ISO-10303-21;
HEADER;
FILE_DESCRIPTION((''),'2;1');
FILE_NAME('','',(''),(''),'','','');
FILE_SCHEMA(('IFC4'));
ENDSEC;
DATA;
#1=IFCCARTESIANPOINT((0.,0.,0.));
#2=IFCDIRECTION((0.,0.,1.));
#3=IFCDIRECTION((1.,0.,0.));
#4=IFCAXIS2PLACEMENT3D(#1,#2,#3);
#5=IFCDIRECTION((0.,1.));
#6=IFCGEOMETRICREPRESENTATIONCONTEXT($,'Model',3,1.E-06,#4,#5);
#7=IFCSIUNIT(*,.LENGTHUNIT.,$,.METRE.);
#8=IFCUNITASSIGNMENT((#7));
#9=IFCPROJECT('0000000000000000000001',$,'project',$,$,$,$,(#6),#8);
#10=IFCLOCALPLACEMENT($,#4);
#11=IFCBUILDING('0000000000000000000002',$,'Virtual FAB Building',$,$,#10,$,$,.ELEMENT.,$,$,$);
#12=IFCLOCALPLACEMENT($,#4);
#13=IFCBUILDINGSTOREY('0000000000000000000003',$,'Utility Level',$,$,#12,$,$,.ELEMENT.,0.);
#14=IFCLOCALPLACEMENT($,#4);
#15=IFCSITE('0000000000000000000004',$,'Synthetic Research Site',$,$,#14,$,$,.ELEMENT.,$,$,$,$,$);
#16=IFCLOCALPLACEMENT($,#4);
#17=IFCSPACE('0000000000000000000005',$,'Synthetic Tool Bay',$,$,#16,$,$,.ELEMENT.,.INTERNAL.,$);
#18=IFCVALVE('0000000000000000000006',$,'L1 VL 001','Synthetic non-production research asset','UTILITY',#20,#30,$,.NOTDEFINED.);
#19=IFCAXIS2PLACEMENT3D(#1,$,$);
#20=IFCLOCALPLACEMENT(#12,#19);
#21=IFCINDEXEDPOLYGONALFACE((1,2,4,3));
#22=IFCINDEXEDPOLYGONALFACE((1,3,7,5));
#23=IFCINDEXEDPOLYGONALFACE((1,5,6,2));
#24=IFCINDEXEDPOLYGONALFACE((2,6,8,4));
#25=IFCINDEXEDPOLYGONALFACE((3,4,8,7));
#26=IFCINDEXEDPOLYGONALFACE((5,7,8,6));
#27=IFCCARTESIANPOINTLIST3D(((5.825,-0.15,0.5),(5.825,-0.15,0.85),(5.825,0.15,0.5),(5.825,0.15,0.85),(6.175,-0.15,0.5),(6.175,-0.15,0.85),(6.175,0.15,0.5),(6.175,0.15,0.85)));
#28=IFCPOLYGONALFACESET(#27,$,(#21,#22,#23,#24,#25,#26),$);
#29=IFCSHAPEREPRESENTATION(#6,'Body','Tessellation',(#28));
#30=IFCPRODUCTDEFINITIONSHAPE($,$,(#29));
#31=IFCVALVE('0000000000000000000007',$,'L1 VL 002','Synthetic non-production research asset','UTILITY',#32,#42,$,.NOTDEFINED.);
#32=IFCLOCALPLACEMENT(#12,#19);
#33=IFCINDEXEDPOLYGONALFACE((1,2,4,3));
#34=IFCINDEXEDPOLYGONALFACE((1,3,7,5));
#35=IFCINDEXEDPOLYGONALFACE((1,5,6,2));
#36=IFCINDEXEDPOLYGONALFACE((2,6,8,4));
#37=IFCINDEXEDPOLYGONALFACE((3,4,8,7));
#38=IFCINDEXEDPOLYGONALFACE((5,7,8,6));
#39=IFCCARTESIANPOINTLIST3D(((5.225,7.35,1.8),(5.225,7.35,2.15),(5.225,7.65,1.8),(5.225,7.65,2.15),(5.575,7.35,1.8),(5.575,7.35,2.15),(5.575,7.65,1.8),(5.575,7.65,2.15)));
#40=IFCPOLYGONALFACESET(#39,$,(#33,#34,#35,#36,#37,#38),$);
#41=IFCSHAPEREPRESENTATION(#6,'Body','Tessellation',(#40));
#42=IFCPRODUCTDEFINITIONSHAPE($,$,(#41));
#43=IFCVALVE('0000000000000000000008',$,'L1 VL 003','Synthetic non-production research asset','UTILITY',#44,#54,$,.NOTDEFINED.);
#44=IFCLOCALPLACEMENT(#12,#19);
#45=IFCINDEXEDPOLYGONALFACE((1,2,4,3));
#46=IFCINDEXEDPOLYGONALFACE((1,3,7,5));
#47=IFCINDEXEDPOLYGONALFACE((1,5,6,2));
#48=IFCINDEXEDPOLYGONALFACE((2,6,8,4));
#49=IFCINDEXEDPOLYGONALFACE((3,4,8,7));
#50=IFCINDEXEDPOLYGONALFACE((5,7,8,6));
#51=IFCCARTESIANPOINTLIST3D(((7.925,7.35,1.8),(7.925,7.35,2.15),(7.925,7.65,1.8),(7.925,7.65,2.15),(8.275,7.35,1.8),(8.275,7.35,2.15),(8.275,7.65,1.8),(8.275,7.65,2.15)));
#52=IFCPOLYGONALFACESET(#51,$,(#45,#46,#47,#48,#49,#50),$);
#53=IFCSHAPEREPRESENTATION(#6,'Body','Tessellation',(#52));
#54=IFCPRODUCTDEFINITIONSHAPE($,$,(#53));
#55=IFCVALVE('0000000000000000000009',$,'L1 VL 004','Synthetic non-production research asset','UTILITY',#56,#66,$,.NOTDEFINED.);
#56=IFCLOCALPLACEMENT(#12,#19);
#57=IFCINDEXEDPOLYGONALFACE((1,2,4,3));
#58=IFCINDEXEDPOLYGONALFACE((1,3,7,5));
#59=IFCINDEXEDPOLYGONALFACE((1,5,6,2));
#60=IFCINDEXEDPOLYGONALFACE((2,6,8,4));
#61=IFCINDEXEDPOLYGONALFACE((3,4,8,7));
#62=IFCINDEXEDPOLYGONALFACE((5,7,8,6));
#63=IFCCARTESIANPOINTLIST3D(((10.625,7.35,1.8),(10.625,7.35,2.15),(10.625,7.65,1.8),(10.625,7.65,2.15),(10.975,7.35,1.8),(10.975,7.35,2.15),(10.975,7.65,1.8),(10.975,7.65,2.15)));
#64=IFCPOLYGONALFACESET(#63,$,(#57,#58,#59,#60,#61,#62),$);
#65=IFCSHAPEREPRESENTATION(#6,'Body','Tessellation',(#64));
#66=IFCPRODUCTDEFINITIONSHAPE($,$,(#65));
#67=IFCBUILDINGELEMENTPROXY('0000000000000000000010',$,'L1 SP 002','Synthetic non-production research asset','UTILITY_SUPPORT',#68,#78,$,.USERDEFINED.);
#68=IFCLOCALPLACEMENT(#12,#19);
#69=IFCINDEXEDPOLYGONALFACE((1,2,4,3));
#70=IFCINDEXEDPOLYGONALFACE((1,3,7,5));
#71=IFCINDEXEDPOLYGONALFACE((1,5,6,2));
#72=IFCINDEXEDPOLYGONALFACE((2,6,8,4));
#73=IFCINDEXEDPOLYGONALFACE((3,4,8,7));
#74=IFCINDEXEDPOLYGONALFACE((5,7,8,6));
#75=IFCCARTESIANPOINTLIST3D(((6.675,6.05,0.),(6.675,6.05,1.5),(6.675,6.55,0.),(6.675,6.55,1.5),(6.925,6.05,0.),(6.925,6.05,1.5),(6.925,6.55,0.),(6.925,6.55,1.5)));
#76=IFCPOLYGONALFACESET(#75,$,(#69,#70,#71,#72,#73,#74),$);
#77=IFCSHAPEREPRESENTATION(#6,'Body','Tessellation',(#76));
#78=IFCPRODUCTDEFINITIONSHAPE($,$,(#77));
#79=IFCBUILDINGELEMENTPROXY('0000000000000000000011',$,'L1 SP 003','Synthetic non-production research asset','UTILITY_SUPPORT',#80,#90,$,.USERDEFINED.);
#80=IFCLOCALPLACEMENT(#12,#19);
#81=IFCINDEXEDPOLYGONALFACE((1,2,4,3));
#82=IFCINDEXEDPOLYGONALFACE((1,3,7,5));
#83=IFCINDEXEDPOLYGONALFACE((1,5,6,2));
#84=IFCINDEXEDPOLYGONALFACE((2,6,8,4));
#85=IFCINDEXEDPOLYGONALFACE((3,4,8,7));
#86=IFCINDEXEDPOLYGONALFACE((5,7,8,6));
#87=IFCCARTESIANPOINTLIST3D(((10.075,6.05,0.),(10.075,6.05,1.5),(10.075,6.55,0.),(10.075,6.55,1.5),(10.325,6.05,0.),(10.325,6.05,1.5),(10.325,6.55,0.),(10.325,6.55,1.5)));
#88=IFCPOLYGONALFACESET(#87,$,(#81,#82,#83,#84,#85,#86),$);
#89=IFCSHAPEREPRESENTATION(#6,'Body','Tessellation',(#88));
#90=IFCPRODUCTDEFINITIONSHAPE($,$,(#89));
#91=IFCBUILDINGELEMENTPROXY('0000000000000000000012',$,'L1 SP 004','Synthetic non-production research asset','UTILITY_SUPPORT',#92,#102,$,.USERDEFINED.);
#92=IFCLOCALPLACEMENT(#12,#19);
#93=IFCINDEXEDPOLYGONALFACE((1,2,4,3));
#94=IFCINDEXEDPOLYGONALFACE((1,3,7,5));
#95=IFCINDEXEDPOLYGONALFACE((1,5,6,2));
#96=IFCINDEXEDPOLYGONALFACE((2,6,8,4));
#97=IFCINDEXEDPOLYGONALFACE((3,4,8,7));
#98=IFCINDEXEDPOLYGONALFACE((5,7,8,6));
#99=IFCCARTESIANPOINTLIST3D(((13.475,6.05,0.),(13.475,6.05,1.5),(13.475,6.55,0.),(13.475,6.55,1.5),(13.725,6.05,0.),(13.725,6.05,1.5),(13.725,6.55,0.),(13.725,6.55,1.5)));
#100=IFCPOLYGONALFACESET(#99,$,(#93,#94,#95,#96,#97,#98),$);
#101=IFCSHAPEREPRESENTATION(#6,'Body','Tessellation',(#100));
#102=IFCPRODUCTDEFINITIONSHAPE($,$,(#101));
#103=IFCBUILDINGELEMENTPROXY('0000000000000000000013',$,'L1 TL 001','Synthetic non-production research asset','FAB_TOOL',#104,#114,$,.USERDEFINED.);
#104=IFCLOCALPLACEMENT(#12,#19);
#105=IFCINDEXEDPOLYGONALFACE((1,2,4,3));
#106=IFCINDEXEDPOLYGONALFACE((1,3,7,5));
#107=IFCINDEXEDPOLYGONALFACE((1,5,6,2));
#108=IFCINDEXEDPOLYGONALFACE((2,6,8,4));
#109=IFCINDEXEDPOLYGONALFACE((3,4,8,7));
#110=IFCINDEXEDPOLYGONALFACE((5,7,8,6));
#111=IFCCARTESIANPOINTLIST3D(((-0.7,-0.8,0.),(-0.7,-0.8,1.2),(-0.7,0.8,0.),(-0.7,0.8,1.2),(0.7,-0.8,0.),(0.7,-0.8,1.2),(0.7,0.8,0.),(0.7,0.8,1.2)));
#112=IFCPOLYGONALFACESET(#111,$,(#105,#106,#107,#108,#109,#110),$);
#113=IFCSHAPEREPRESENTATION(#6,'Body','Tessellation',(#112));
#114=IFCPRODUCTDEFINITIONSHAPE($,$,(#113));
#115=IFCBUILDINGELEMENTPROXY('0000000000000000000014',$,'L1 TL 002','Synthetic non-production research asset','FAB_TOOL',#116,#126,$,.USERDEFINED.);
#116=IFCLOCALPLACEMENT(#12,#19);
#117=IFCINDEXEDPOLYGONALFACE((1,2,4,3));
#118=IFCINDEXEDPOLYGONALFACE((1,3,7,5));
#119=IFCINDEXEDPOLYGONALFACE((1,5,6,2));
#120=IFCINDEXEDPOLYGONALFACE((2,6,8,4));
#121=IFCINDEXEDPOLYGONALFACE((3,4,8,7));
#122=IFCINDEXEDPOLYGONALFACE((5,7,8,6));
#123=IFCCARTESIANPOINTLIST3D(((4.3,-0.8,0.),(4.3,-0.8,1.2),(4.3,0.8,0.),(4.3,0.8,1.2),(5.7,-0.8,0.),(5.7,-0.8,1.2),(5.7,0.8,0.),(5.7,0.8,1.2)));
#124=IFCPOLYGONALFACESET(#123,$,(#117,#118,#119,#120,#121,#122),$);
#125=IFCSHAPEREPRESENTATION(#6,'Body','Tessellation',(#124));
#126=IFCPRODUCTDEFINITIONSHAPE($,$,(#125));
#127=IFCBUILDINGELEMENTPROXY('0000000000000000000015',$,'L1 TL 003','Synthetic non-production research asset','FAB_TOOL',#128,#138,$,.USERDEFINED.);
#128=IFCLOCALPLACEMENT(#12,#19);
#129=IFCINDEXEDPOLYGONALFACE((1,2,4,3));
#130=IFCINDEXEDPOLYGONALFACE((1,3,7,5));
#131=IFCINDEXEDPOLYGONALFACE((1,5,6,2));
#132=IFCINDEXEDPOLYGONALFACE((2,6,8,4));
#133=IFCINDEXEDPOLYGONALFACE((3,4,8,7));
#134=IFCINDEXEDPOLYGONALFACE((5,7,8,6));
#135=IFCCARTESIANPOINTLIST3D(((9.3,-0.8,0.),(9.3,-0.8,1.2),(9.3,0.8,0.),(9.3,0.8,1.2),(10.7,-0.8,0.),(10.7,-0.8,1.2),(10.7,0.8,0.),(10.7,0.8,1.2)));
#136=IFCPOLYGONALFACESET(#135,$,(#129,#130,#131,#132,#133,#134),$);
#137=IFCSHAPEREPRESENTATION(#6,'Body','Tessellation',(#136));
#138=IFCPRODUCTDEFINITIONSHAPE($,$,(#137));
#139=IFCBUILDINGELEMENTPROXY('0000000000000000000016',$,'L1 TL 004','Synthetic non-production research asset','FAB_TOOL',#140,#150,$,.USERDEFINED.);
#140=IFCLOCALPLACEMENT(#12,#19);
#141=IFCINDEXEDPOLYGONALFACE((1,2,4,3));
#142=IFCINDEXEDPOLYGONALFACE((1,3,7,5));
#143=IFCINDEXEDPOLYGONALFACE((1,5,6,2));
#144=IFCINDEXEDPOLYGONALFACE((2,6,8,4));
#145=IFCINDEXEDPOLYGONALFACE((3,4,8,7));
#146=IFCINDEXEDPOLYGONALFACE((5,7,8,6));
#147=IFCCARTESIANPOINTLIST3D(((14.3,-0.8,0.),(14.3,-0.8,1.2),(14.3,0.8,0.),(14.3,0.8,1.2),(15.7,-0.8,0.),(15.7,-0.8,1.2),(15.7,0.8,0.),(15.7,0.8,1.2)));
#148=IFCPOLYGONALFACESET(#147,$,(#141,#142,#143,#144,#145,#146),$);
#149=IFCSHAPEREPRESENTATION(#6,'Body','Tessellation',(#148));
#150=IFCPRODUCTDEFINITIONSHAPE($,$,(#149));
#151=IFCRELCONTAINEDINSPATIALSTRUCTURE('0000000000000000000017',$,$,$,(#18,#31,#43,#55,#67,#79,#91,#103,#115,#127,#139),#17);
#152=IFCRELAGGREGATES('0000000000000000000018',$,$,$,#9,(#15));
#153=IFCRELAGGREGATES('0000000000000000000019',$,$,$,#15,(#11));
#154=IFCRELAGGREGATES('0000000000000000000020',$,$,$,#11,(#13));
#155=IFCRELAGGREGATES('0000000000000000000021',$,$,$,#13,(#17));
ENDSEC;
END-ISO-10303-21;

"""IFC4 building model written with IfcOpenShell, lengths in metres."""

from ifc_helpers import new_model, si_unit, direction, frame, origin_with_axes, origin_2d_with_axis, place, context, project, spatial, rectangle, extrude, element, save


model = new_model("IFC4")

# Units and contexts
model_context = context("Model", 3, precision=1e-06, world=origin_with_axes(), true_north=direction((0.0, 1.0)))
ifc_project = project(units=[si_unit("LENGTHUNIT", "METRE")], contexts=[model_context])

# Site, building, storey, space
site_placement = place(None, origin_with_axes())
site = spatial("IfcSite", under=ifc_project, at=site_placement, Name="Synthetic Research Site", CompositionType="ELEMENT")
building_placement = place(None, origin_with_axes())
building = spatial("IfcBuilding", under=site, at=building_placement, Name="Virtual FAB Building", CompositionType="ELEMENT")
storey_placement = place(None, origin_with_axes())
storey = spatial("IfcBuildingStorey", under=building, at=storey_placement, Name="Utility Level", CompositionType="ELEMENT", Elevation=0.0)
space_placement = place(None, origin_with_axes())
space = spatial("IfcSpace", under=storey, at=space_placement, Name="Synthetic Tool Bay", CompositionType="ELEMENT", PredefinedType="INTERNAL")

# Valves
for number, where, z_axis, x_axis, name in (
    (1, (6.0, 0.0, 0.5), (0.0, 0.0, 1.0), (1.0, 0.0, 0.0), "L1 VL 001"),
    (2, (5.4, 7.5, 1.8), (0.0, 0.0, 1.0), (1.0, 0.0, 0.0), "L1 VL 002"),
    (3, (8.1, 7.5, 1.8), (0.0, 0.0, 1.0), (1.0, 0.0, 0.0), "L1 VL 003"),
    (4, (10.8, 7.5, 1.8), (0.0, 0.0, 1.0), (1.0, 0.0, 0.0), "L1 VL 004"),
):
    element("IfcValve", number, at=place(None, frame(where, z_axis=z_axis, x_axis=x_axis)), inside=space, Name=name, Description="Synthetic non-production research asset", ObjectType="UTILITY", PredefinedType="NOTDEFINED", context=model_context, shape_type="SweptSolid", body=[
        extrude(rectangle(XDim=0.35, YDim=0.3, at=origin_2d_with_axis()), origin_with_axes(), (0.0, 0.0, 1.0), 0.35),
    ])

# Building element proxies
for number, where, z_axis, x_axis, name in (
    (5, (6.8, 6.3, 0.0), (0.0, 0.0, 1.0), (1.0, 0.0, 0.0), "L1 SP 002"),
    (6, (10.2, 6.3, 0.0), (0.0, 0.0, 1.0), (1.0, 0.0, 0.0), "L1 SP 003"),
    (7, (13.6, 6.3, 0.0), (0.0, 0.0, 1.0), (1.0, 0.0, 0.0), "L1 SP 004"),
):
    element("IfcBuildingElementProxy", number, at=place(None, frame(where, z_axis=z_axis, x_axis=x_axis)), inside=space, Name=name, Description="Synthetic non-production research asset", ObjectType="UTILITY_SUPPORT", PredefinedType="USERDEFINED", context=model_context, shape_type="SweptSolid", body=[
        extrude(rectangle(XDim=0.25, YDim=0.5, at=origin_2d_with_axis()), origin_with_axes(), (0.0, 0.0, 1.0), 1.5),
    ])
for number, where, z_axis, x_axis, name in (
    (8, (0.0, 0.0, 0.0), (0.0, 0.0, 1.0), (1.0, 0.0, 0.0), "L1 TL 001"),
    (9, (5.0, 0.0, 0.0), (0.0, 0.0, 1.0), (1.0, 0.0, 0.0), "L1 TL 002"),
    (10, (10.0, 0.0, 0.0), (0.0, 0.0, 1.0), (1.0, 0.0, 0.0), "L1 TL 003"),
    (11, (15.0, 0.0, 0.0), (0.0, 0.0, 1.0), (1.0, 0.0, 0.0), "L1 TL 004"),
):
    element("IfcBuildingElementProxy", number, at=place(None, frame(where, z_axis=z_axis, x_axis=x_axis)), inside=space, Name=name, Description="Synthetic non-production research asset", ObjectType="FAB_TOOL", PredefinedType="USERDEFINED", context=model_context, shape_type="SweptSolid", body=[
        extrude(rectangle(XDim=1.4, YDim=1.6, at=origin_2d_with_axis()), origin_with_axes(), (0.0, 0.0, 1.0), 1.2),
    ])

save(model, "model.ifc")
